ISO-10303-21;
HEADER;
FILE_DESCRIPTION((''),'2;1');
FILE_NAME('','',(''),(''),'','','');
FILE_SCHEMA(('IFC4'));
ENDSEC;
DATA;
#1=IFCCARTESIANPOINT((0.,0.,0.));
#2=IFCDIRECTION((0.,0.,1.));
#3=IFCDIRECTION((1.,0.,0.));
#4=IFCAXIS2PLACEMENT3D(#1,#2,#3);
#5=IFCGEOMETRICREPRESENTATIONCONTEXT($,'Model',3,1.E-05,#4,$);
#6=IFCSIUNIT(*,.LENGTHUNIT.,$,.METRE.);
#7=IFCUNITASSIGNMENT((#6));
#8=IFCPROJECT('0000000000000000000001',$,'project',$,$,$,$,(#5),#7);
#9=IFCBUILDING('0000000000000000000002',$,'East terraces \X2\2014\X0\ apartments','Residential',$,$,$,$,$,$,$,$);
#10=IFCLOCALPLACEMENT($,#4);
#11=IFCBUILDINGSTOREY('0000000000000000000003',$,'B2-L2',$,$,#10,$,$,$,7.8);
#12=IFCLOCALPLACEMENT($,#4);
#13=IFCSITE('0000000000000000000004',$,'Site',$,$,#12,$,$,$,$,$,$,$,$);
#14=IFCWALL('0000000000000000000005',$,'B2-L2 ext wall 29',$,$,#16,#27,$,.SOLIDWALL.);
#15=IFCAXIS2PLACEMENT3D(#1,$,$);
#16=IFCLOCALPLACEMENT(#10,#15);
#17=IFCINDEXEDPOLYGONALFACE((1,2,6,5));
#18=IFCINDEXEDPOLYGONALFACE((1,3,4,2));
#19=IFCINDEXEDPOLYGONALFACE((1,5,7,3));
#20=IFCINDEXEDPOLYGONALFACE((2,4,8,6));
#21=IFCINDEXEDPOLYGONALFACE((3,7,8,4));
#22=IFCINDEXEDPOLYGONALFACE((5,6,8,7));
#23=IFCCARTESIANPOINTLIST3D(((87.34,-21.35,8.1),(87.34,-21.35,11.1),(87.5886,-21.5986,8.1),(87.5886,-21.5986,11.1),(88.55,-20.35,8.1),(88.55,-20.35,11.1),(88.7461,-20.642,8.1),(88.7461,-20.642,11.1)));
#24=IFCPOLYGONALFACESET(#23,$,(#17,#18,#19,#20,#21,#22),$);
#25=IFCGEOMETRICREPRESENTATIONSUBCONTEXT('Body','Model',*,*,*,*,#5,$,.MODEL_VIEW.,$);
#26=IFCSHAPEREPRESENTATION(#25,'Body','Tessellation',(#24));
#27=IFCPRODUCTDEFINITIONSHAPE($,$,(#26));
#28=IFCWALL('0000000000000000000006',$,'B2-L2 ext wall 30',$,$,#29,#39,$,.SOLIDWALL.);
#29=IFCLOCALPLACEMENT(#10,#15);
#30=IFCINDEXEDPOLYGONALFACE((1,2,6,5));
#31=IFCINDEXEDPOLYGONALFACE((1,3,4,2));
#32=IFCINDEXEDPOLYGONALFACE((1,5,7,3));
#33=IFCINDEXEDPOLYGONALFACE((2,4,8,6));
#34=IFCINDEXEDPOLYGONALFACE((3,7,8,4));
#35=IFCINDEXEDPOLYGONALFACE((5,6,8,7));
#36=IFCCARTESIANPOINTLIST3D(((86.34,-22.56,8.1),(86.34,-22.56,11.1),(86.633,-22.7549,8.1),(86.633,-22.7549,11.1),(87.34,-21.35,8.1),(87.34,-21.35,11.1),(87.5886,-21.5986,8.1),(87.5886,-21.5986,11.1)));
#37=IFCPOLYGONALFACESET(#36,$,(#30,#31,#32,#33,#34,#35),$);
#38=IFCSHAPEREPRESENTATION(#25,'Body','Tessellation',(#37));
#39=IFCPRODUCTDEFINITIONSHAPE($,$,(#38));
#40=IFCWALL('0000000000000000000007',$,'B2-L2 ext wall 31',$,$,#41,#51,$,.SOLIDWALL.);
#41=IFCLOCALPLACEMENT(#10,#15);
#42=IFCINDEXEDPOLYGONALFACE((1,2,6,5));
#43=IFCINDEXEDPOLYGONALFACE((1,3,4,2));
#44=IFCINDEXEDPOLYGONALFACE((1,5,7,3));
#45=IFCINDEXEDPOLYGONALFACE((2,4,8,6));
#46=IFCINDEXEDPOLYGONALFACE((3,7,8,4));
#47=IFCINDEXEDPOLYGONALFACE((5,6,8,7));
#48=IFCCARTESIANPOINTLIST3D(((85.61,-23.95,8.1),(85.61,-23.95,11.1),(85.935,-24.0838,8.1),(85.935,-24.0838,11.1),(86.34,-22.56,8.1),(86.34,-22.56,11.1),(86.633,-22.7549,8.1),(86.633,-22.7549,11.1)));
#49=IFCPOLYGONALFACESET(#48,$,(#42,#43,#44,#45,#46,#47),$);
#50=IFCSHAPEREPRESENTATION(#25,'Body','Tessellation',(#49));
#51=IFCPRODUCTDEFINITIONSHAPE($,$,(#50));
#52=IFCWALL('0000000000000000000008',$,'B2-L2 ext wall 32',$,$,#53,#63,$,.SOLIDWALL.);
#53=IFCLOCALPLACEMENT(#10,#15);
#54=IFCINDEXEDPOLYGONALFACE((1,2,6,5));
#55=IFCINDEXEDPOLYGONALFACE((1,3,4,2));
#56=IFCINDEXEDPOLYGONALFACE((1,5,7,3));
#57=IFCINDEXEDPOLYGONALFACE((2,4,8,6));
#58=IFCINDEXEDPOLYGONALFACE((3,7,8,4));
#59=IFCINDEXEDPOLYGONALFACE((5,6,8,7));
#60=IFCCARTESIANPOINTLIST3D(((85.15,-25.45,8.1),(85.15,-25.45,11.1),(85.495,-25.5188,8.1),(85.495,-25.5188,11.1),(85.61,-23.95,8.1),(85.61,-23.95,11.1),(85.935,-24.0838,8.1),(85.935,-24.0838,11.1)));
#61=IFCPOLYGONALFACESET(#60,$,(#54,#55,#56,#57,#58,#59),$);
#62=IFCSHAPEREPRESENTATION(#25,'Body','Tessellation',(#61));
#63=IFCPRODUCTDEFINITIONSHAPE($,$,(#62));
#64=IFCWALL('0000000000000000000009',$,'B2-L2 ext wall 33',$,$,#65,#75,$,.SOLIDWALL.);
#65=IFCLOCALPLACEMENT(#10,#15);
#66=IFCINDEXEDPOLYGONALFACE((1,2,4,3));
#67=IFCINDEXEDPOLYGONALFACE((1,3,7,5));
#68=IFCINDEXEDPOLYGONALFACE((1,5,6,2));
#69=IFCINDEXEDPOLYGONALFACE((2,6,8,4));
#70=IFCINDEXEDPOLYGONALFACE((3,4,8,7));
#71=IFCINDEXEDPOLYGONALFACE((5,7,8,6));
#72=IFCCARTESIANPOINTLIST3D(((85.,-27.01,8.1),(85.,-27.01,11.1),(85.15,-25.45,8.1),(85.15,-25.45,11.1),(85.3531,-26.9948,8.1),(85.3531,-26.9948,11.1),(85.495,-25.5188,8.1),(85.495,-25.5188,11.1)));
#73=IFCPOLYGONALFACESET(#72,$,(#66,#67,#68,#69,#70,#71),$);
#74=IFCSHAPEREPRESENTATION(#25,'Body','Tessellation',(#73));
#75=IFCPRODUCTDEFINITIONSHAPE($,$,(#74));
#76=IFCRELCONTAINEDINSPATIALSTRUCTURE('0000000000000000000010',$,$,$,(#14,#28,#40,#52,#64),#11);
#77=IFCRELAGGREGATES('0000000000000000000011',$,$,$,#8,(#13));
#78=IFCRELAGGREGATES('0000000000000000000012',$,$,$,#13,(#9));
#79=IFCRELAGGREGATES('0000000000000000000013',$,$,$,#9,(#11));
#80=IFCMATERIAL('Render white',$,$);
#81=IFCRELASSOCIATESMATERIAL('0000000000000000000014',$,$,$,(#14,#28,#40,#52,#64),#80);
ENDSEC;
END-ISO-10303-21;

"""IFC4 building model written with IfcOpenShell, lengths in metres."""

from ifc_helpers import new_model, si_unit, frame, origin_with_axes, place, context, subcontext, project, spatial, polyline, outline, extrude, material, element, save


model = new_model("IFC4")

# Units and contexts
model_context = context("Model", 3, precision=1e-05, world=origin_with_axes())
body_context = subcontext(model_context, "Body", "Model", "MODEL_VIEW")
ifc_project = project(units=[si_unit("LENGTHUNIT", "METRE")], contexts=[model_context])

# Site, building, storey
site_placement = place(None, origin_with_axes())
site = spatial("IfcSite", under=ifc_project, at=site_placement, Name="Site")
building = spatial("IfcBuilding", under=site, Name="East terraces — apartments", Description="Residential")
storey_placement = place(None, origin_with_axes())
storey = spatial("IfcBuildingStorey", under=building, at=storey_placement, Name="B2-L2", Elevation=7.8)

# Shared definitions
ifc_material_1 = material(Name="Render white")

# Walls
wall_1_placement = place(storey_placement, origin_with_axes())
element("IfcWall", 1, at=wall_1_placement, inside=storey, material=ifc_material_1, Name="B2-L2 ext wall 29", PredefinedType="SOLIDWALL", context=body_context, shape_type="SweptSolid", body=[
    extrude(outline(polyline([(88.55, -20.35), (87.34, -21.35), (87.5886, -21.5986), (88.7461, -20.642), (88.55, -20.35)])), frame((0.0, 0.0, 8.1), z_axis=(0.0, 0.0, 1.0), x_axis=(1.0, 0.0, 0.0)), (0.0, 0.0, 1.0), 3.0),
])
wall_2_placement = place(storey_placement, origin_with_axes())
element("IfcWall", 2, at=wall_2_placement, inside=storey, material=ifc_material_1, Name="B2-L2 ext wall 30", PredefinedType="SOLIDWALL", context=body_context, shape_type="SweptSolid", body=[
    extrude(outline(polyline([(87.34, -21.35), (86.34, -22.56), (86.633, -22.7549), (87.5886, -21.5986), (87.34, -21.35)])), frame((0.0, 0.0, 8.1), z_axis=(0.0, 0.0, 1.0), x_axis=(1.0, 0.0, 0.0)), (0.0, 0.0, 1.0), 3.0),
])
wall_3_placement = place(storey_placement, origin_with_axes())
element("IfcWall", 3, at=wall_3_placement, inside=storey, material=ifc_material_1, Name="B2-L2 ext wall 31", PredefinedType="SOLIDWALL", context=body_context, shape_type="SweptSolid", body=[
    extrude(outline(polyline([(86.34, -22.56), (85.61, -23.95), (85.935, -24.0838), (86.633, -22.7549), (86.34, -22.56)])), frame((0.0, 0.0, 8.1), z_axis=(0.0, 0.0, 1.0), x_axis=(1.0, 0.0, 0.0)), (0.0, 0.0, 1.0), 3.0),
])
wall_4_placement = place(storey_placement, origin_with_axes())
element("IfcWall", 4, at=wall_4_placement, inside=storey, material=ifc_material_1, Name="B2-L2 ext wall 32", PredefinedType="SOLIDWALL", context=body_context, shape_type="SweptSolid", body=[
    extrude(outline(polyline([(85.61, -23.95), (85.15, -25.45), (85.495, -25.5188), (85.935, -24.0838), (85.61, -23.95)])), frame((0.0, 0.0, 8.1), z_axis=(0.0, 0.0, 1.0), x_axis=(1.0, 0.0, 0.0)), (0.0, 0.0, 1.0), 3.0),
])
wall_5_placement = place(storey_placement, origin_with_axes())
element("IfcWall", 5, at=wall_5_placement, inside=storey, material=ifc_material_1, Name="B2-L2 ext wall 33", PredefinedType="SOLIDWALL", context=body_context, shape_type="SweptSolid", body=[
    extrude(outline(polyline([(85.15, -25.45), (85.0, -27.01), (85.3531, -26.9948), (85.495, -25.5188), (85.15, -25.45)])), frame((0.0, 0.0, 8.1), z_axis=(0.0, 0.0, 1.0), x_axis=(1.0, 0.0, 0.0)), (0.0, 0.0, 1.0), 3.0),
])

save(model, "model.ifc")
